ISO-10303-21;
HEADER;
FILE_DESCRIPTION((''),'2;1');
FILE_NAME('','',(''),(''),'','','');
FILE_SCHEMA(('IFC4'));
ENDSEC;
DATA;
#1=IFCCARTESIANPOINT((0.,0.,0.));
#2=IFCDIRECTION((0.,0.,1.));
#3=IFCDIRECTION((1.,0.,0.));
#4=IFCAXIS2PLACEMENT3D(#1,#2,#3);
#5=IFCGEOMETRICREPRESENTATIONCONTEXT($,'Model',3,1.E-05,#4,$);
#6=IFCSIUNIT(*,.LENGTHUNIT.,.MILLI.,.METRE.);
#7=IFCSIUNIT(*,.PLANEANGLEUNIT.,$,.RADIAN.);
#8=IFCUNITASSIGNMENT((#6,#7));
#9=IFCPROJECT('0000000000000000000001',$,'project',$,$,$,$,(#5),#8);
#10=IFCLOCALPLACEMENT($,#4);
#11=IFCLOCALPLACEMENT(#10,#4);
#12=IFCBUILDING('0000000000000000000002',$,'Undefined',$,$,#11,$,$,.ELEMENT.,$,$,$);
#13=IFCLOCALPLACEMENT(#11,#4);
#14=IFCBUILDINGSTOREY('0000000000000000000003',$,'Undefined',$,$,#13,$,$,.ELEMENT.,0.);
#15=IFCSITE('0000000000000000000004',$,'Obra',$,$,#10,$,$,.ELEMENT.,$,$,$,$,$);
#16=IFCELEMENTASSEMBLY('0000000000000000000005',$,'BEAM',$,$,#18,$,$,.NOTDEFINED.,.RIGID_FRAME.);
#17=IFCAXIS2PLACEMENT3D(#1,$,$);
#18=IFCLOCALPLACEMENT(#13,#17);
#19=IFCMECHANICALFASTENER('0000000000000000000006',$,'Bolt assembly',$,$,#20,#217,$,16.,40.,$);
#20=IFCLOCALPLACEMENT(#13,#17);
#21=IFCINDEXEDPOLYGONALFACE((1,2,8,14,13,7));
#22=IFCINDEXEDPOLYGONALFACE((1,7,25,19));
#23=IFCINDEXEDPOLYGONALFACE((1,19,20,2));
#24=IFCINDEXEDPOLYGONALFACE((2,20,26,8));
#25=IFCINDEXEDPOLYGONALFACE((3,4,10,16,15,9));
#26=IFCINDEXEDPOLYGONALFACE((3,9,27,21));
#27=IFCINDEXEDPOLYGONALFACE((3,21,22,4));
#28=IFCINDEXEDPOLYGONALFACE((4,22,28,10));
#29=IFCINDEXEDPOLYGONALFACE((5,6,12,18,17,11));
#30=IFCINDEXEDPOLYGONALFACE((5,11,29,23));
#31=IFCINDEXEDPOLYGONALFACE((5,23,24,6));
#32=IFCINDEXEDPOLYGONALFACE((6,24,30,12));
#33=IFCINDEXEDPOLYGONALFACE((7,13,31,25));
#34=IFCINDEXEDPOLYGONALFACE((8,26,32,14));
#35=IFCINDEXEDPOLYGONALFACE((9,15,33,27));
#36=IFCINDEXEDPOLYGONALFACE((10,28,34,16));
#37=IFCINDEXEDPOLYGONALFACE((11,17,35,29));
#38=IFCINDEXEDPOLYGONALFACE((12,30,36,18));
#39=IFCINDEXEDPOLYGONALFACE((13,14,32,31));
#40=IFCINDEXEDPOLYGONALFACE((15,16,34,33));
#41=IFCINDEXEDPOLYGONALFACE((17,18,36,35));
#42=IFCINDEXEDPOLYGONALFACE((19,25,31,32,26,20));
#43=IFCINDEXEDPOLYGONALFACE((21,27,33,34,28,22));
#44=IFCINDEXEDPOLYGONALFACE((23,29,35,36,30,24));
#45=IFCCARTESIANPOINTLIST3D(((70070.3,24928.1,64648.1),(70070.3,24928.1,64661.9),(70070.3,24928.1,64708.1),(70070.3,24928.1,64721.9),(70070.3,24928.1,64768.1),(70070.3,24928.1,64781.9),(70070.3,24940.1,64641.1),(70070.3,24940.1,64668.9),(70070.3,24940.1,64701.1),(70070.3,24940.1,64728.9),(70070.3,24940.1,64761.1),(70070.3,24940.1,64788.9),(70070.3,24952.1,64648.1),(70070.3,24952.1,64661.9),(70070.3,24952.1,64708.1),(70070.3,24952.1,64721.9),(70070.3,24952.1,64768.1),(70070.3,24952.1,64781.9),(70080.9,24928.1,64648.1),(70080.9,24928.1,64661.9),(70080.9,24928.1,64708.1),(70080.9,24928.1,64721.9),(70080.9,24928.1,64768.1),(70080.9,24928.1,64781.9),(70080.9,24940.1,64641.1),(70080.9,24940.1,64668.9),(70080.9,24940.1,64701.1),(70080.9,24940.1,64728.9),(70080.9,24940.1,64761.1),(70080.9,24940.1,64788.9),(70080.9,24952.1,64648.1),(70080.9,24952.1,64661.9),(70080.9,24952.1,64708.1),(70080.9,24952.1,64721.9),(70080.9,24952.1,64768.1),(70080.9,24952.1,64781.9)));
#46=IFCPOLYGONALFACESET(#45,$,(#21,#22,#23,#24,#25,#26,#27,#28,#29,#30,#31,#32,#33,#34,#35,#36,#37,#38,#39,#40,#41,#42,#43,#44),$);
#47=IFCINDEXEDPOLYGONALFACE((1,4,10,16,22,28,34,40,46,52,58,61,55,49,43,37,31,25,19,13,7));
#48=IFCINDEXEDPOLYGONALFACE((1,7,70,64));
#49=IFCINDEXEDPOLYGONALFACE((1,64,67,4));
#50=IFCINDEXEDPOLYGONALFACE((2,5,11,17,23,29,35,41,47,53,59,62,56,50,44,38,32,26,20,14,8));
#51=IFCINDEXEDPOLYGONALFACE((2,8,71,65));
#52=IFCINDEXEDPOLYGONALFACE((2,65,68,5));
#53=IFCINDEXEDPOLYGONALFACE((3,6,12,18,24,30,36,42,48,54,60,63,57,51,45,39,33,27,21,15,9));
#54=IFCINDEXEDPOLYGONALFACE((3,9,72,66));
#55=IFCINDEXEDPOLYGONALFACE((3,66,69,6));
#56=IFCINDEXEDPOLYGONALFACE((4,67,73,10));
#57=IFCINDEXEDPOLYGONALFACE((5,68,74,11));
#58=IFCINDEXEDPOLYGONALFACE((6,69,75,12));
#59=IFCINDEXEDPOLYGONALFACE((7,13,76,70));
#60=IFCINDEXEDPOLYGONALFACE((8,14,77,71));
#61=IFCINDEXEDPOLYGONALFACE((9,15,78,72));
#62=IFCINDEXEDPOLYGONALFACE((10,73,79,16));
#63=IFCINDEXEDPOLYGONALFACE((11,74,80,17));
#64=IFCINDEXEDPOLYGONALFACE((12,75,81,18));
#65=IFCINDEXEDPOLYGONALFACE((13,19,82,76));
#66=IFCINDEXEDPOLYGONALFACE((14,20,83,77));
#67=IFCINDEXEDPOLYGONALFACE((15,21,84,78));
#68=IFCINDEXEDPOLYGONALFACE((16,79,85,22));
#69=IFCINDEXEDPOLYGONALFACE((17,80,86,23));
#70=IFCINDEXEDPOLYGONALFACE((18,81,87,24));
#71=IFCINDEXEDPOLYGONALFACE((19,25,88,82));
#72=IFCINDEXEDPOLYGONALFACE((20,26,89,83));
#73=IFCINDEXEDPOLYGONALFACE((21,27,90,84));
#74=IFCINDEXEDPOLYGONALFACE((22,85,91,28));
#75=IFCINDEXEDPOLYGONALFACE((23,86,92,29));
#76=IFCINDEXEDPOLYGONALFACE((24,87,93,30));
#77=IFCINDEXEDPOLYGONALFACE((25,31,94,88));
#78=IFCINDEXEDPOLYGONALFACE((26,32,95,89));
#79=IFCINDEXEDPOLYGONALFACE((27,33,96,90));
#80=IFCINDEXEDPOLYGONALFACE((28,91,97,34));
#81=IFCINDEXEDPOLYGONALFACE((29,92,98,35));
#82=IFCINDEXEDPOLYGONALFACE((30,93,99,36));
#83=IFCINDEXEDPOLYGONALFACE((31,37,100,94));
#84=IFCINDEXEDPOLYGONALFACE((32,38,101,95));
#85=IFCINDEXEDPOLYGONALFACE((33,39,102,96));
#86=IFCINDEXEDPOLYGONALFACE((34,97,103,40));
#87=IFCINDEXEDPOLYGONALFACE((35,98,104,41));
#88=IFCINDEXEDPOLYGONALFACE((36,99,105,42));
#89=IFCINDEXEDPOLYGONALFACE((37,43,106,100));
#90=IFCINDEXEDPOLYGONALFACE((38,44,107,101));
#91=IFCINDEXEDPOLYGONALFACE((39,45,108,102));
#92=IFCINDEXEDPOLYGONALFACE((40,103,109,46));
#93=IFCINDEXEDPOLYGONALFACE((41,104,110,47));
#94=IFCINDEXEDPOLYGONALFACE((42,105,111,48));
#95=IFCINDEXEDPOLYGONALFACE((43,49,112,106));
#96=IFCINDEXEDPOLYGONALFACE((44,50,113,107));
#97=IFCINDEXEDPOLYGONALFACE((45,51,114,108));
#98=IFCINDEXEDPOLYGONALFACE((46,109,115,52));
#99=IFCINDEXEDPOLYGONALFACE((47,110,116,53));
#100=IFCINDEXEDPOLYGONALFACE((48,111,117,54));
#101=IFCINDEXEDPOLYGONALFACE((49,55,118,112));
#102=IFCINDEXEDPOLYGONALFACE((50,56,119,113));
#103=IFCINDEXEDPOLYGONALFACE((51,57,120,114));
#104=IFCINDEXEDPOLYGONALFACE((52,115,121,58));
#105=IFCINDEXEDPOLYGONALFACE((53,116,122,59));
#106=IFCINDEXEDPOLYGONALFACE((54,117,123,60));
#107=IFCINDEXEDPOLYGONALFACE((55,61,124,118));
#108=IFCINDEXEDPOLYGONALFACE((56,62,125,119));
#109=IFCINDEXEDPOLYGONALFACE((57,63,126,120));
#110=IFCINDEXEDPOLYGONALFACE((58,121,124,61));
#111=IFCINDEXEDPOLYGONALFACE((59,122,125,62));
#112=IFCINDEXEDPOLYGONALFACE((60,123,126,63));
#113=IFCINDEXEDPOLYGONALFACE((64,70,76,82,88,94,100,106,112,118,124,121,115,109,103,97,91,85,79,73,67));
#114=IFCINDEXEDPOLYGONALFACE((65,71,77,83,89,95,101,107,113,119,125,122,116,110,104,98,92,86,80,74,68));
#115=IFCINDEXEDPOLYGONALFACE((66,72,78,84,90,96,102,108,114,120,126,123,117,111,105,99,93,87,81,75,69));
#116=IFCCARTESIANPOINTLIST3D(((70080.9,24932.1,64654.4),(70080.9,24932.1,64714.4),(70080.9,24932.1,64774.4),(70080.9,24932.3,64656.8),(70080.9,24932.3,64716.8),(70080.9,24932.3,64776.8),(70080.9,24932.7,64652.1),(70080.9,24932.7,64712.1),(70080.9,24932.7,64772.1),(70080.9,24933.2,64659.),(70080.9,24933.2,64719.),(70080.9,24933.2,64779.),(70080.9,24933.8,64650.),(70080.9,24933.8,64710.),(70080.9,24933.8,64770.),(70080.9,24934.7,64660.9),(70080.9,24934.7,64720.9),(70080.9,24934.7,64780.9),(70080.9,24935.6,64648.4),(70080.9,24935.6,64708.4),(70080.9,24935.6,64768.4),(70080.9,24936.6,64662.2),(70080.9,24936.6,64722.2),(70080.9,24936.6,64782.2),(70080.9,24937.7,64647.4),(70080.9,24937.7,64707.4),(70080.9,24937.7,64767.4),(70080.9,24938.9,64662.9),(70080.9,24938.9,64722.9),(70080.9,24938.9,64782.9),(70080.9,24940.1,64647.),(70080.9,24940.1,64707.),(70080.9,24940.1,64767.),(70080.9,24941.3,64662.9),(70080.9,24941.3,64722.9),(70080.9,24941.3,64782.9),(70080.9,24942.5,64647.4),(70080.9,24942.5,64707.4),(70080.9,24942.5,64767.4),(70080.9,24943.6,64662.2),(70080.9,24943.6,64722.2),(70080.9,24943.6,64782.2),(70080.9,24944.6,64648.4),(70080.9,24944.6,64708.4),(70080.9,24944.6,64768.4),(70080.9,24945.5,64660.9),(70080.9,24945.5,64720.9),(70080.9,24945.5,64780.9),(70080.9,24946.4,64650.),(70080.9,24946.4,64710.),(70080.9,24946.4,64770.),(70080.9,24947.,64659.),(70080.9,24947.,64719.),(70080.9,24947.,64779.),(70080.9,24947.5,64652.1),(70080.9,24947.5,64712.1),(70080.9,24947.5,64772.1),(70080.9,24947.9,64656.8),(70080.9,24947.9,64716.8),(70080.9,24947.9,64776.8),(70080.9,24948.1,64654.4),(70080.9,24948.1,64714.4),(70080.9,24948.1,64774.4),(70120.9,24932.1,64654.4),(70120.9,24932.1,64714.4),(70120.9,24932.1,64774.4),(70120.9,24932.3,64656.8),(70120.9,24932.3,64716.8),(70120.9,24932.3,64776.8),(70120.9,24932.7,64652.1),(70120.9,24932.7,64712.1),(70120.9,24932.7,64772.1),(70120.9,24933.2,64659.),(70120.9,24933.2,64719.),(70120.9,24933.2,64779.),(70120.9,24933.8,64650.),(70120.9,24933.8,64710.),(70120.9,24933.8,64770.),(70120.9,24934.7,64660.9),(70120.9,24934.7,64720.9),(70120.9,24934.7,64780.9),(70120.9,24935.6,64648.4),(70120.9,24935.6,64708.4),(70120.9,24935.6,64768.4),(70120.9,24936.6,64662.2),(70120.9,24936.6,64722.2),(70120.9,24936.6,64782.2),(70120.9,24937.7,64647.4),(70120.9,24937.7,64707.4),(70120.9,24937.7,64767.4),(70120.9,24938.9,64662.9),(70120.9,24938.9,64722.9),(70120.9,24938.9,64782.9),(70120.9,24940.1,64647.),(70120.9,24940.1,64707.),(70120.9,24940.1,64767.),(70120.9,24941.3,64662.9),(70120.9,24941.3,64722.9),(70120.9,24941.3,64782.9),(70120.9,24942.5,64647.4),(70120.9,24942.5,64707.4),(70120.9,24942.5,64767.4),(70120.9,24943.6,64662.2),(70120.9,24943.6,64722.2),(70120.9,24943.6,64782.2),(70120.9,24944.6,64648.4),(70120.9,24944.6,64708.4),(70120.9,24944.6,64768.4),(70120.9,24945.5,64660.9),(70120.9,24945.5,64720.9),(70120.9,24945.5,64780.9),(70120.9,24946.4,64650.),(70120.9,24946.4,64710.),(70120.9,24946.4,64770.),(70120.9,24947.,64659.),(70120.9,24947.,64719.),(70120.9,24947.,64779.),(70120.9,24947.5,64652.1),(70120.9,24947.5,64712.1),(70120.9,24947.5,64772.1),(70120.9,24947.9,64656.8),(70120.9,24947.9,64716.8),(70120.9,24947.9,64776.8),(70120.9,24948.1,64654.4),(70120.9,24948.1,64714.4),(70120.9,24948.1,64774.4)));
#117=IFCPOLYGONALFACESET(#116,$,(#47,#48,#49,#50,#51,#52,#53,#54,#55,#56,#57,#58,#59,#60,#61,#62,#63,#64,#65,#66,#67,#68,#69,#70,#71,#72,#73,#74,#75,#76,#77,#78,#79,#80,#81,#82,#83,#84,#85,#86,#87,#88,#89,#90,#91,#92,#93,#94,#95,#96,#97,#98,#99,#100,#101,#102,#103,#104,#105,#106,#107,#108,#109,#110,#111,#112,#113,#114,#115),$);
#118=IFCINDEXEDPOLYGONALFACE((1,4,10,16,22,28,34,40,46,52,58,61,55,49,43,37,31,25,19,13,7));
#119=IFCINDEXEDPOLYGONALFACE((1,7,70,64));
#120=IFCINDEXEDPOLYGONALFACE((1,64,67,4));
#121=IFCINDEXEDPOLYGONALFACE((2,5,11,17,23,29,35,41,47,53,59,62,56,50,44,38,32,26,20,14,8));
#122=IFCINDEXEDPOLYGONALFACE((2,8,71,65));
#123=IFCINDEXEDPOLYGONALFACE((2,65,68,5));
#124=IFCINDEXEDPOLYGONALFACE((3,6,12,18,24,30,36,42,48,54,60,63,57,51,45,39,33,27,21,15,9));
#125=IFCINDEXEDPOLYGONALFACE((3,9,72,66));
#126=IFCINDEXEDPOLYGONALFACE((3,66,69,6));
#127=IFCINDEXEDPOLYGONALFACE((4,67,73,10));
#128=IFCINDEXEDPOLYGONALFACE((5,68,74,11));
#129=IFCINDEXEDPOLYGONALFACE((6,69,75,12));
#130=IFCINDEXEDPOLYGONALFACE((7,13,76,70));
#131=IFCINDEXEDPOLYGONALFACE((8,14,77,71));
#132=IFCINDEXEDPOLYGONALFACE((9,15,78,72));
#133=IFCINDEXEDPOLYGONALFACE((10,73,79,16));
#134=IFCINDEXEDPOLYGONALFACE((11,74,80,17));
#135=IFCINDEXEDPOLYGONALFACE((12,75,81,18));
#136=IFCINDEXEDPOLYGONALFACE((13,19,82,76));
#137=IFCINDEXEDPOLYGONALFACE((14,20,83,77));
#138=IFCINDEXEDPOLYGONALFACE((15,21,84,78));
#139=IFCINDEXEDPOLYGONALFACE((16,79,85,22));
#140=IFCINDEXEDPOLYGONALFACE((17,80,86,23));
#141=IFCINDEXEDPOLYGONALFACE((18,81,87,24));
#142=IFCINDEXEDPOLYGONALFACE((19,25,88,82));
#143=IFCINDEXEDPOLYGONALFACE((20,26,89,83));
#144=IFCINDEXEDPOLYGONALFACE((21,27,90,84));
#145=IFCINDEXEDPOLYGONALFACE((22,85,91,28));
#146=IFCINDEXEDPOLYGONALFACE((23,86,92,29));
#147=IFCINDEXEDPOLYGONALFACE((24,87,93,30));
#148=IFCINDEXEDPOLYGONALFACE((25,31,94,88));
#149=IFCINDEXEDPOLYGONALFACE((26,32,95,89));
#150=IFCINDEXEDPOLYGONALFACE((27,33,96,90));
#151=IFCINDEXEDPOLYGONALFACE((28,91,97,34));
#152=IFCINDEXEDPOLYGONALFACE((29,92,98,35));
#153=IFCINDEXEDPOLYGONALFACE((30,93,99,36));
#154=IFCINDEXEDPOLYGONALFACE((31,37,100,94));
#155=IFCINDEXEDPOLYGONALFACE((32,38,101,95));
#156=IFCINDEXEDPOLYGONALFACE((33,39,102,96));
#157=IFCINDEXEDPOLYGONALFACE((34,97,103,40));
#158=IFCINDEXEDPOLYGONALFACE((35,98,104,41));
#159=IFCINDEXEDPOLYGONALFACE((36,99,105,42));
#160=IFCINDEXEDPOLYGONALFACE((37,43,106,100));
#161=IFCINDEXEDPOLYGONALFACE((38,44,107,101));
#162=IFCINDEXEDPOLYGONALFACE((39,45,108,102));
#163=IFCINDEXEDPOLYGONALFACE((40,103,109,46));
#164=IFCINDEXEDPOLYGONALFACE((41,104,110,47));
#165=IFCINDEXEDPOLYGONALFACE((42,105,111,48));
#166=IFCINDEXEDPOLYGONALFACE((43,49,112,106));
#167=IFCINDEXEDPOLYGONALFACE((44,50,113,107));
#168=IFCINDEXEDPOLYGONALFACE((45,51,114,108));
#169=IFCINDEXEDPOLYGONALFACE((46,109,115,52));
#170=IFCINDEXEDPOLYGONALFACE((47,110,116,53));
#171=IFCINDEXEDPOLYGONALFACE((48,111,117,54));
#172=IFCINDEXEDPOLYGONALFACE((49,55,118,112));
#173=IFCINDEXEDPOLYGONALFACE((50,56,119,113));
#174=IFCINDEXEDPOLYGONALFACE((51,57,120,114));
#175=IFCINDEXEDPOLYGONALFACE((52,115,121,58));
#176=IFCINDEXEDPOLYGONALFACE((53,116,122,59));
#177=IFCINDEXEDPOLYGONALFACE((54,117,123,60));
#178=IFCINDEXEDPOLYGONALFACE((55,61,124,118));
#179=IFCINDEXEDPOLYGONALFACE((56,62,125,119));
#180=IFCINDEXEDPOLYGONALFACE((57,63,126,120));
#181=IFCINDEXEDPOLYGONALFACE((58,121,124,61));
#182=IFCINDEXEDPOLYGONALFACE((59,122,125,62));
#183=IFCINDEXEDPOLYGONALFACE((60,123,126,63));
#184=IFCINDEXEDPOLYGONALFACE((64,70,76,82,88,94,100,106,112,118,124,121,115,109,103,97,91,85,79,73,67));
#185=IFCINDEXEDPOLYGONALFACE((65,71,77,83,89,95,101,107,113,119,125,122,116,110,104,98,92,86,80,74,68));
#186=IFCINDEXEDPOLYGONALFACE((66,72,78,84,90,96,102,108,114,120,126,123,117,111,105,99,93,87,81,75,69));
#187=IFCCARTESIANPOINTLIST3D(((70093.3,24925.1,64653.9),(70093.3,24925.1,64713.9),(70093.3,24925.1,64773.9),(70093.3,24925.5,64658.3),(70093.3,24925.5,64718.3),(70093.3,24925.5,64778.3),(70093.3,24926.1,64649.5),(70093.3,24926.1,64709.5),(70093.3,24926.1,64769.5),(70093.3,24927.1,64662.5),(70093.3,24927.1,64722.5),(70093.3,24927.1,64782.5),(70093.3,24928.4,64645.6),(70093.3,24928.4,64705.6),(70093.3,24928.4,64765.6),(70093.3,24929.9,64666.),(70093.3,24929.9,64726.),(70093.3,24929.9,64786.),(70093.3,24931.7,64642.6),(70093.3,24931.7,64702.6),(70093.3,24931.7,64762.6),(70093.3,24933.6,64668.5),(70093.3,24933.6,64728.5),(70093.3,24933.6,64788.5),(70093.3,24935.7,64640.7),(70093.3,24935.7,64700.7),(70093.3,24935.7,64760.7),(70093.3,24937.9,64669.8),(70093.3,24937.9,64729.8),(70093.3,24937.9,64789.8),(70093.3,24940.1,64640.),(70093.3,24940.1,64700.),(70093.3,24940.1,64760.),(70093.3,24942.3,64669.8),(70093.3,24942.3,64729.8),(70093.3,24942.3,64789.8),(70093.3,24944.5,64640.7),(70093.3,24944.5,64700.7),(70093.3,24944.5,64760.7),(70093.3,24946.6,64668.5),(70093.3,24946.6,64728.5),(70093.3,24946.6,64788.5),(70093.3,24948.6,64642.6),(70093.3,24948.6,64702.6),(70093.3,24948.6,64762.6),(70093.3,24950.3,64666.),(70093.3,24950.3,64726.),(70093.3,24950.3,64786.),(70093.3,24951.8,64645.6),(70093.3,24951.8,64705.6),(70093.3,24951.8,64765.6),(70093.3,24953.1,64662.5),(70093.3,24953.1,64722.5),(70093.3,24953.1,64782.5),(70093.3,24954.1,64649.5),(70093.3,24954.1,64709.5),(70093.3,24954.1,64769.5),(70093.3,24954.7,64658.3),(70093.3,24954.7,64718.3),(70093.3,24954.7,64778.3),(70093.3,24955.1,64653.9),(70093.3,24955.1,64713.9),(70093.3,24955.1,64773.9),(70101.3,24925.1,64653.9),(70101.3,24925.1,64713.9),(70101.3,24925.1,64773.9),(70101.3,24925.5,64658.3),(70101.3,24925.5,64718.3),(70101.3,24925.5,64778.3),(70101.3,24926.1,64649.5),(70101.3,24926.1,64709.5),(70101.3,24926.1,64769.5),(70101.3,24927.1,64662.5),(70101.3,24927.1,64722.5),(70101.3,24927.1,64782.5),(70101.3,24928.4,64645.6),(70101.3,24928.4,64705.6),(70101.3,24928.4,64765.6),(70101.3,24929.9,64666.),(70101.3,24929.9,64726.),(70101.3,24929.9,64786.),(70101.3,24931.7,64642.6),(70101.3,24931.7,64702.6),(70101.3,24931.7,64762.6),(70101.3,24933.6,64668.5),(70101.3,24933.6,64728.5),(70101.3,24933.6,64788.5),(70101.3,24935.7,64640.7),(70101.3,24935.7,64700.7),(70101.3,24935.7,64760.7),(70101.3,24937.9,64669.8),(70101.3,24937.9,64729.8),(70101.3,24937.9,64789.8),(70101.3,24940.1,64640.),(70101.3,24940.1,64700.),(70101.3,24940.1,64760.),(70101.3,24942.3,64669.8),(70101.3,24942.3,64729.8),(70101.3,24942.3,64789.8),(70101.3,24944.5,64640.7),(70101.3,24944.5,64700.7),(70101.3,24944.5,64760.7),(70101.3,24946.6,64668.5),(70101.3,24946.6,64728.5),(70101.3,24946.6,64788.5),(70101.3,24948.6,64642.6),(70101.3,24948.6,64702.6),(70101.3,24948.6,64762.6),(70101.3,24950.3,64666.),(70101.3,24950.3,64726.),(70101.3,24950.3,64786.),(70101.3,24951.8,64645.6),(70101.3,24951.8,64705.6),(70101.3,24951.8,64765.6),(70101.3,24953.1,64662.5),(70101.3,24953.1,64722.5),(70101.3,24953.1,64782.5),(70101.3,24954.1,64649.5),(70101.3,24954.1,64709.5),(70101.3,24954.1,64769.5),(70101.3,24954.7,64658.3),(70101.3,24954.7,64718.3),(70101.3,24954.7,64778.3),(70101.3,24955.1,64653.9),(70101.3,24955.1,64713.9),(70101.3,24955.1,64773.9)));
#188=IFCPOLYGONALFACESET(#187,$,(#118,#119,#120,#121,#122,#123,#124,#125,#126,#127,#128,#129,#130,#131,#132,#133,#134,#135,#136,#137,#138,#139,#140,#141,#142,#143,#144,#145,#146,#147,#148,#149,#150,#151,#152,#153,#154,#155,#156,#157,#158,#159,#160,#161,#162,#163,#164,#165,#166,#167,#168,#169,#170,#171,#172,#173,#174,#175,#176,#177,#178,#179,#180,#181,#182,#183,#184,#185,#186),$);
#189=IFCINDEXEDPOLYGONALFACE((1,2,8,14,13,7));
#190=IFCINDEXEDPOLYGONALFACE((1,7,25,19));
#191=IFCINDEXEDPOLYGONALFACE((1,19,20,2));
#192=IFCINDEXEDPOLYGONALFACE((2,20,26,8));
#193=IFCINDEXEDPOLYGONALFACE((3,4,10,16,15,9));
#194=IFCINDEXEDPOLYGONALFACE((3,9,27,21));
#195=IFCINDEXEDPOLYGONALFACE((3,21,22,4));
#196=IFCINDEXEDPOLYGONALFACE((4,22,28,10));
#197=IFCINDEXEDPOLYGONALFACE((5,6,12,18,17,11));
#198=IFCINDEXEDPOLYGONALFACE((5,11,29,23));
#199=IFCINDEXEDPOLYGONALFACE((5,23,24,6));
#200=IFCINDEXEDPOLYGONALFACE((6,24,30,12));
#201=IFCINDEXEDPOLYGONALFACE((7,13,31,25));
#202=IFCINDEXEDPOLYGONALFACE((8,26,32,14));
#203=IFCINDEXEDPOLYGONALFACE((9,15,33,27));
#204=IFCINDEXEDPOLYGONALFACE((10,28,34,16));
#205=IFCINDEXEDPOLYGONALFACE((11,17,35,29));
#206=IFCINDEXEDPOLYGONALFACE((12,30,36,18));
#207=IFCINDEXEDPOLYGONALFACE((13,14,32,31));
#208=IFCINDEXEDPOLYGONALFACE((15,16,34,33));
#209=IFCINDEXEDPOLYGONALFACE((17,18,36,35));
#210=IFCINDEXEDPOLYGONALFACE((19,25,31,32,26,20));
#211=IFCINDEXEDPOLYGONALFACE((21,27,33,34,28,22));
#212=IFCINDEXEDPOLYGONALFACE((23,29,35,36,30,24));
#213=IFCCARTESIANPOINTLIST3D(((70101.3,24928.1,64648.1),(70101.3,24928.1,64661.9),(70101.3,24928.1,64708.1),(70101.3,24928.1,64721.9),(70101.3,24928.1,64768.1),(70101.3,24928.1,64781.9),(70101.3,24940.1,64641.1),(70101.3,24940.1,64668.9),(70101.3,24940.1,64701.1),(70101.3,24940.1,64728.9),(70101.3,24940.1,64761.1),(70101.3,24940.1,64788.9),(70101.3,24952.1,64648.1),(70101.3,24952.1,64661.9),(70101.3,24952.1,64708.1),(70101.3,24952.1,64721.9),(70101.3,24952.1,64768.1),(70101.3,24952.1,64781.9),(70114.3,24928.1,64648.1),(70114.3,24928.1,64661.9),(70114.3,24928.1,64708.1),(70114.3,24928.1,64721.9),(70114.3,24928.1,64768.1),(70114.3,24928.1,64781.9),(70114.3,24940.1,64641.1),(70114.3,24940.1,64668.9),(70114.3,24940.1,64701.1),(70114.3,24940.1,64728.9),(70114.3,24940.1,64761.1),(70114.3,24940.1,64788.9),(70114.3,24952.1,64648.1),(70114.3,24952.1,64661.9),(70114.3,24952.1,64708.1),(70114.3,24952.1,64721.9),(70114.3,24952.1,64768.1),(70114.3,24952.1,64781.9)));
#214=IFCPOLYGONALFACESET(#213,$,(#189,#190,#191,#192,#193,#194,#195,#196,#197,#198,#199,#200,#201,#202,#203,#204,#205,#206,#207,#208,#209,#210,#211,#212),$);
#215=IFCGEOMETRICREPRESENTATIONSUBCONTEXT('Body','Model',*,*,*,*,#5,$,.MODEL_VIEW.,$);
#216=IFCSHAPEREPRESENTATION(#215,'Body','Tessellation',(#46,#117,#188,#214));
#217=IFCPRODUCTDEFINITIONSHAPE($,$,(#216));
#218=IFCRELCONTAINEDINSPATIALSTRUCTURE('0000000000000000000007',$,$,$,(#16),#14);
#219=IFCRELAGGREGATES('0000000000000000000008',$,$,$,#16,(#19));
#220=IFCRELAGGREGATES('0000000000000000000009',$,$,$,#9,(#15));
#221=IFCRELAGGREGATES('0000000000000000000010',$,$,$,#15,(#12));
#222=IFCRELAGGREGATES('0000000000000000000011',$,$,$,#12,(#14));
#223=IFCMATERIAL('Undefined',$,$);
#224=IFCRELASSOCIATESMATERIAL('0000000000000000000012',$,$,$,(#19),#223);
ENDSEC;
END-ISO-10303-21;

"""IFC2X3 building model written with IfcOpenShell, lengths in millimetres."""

from ifc_helpers import new_model, si_unit, frame, origin_with_axes, origin_2d_with_axis, place, context, subcontext, project, spatial, polyline, circle, outline, extrude, source, transform, mapped, material, element, aggregate, save


model = new_model("IFC2X3")

# Units and contexts
model_context = context("Model", 3, precision=1e-05, world=origin_with_axes())
body_context = subcontext(model_context, "Body", "Model", "MODEL_VIEW")
ifc_project = project(units=[si_unit("LENGTHUNIT", "METRE", prefix="MILLI"), si_unit("PLANEANGLEUNIT", "RADIAN")], contexts=[model_context])

# Site, building, storey
site_placement = place(None, origin_with_axes())
site = spatial("IfcSite", under=ifc_project, at=site_placement, Name="Obra", CompositionType="ELEMENT")
building_placement = place(site_placement, origin_with_axes())
building = spatial("IfcBuilding", under=site, at=building_placement, Name="Undefined", CompositionType="ELEMENT")
storey_placement = place(building_placement, origin_with_axes())
storey = spatial("IfcBuildingStorey", under=building, at=storey_placement, Name="Undefined", CompositionType="ELEMENT", Elevation=0.0)

# Element assembly
ifc_material_1 = material(Name="Undefined")
assembly_1_placement = place(storey_placement, origin_with_axes())
assembly_1 = element("IfcElementAssembly", 1, at=assembly_1_placement, inside=storey, Name="BEAM", AssemblyPlace="NOTDEFINED", PredefinedType="RIGID_FRAME")

# Mechanical fastener
shared_shape_1 = source(origin_with_axes(), body_context, "Body", "SweptSolid", [
    extrude(outline(polyline([(13.9, 0.0), (6.9, 12.0), (-6.9, 12.0), (-13.9, 0.0), (-6.9, -12.0), (6.9, -12.0), (13.9, 0.0)])), frame((0.0, -19.7, 0.0), z_axis=(0.0, 1.0, 0.0), x_axis=(1.0, 0.0, 0.0)), (0.0, 0.0, 1.0), 10.6),
    extrude(circle(Radius=8.0, at=origin_2d_with_axis()), frame((0.0, -9.1, 0.0), z_axis=(0.0, 1.0, 0.0), x_axis=(1.0, 0.0, 0.0)), (0.0, 0.0, 1.0), 40.0),
    extrude(circle(Radius=15.0, at=origin_2d_with_axis()), frame((0.0, 3.3, 0.0), z_axis=(0.0, 1.0, 0.0), x_axis=(1.0, 0.0, 0.0)), (0.0, 0.0, 1.0), 8.0),
    extrude(outline(polyline([(13.9, 0.0), (6.9, 12.0), (-6.9, 12.0), (-13.9, 0.0), (-6.9, -12.0), (6.9, -12.0), (13.9, 0.0)])), frame((0.0, 11.3, 0.0), z_axis=(0.0, 1.0, 0.0), x_axis=(1.0, 0.0, 0.0)), (0.0, 0.0, 1.0), 13.0),
])
mechanical_fastener_1_placement = place(assembly_1_placement, frame((70090.0, 24990.1, 64835.0), z_axis=(0.000002, -1.0, 0.0), x_axis=(0.0, 0.0, -1.0)))
mechanical_fastener_1 = element("IfcMechanicalFastener", 2, at=mechanical_fastener_1_placement, material=ifc_material_1, Name="Bolt assembly", NominalDiameter=16.0, NominalLength=40.0, context=body_context, shape_type="MappedRepresentation", body=[
    mapped(shared_shape_1, transform((60.0, 0.0, 50.0))),
    mapped(shared_shape_1, transform((120.0, 0.0, 50.0))),
    mapped(shared_shape_1, transform((180.0, 0.0, 50.0))),
])
aggregate(assembly_1, [mechanical_fastener_1])

save(model, "model.ifc")
